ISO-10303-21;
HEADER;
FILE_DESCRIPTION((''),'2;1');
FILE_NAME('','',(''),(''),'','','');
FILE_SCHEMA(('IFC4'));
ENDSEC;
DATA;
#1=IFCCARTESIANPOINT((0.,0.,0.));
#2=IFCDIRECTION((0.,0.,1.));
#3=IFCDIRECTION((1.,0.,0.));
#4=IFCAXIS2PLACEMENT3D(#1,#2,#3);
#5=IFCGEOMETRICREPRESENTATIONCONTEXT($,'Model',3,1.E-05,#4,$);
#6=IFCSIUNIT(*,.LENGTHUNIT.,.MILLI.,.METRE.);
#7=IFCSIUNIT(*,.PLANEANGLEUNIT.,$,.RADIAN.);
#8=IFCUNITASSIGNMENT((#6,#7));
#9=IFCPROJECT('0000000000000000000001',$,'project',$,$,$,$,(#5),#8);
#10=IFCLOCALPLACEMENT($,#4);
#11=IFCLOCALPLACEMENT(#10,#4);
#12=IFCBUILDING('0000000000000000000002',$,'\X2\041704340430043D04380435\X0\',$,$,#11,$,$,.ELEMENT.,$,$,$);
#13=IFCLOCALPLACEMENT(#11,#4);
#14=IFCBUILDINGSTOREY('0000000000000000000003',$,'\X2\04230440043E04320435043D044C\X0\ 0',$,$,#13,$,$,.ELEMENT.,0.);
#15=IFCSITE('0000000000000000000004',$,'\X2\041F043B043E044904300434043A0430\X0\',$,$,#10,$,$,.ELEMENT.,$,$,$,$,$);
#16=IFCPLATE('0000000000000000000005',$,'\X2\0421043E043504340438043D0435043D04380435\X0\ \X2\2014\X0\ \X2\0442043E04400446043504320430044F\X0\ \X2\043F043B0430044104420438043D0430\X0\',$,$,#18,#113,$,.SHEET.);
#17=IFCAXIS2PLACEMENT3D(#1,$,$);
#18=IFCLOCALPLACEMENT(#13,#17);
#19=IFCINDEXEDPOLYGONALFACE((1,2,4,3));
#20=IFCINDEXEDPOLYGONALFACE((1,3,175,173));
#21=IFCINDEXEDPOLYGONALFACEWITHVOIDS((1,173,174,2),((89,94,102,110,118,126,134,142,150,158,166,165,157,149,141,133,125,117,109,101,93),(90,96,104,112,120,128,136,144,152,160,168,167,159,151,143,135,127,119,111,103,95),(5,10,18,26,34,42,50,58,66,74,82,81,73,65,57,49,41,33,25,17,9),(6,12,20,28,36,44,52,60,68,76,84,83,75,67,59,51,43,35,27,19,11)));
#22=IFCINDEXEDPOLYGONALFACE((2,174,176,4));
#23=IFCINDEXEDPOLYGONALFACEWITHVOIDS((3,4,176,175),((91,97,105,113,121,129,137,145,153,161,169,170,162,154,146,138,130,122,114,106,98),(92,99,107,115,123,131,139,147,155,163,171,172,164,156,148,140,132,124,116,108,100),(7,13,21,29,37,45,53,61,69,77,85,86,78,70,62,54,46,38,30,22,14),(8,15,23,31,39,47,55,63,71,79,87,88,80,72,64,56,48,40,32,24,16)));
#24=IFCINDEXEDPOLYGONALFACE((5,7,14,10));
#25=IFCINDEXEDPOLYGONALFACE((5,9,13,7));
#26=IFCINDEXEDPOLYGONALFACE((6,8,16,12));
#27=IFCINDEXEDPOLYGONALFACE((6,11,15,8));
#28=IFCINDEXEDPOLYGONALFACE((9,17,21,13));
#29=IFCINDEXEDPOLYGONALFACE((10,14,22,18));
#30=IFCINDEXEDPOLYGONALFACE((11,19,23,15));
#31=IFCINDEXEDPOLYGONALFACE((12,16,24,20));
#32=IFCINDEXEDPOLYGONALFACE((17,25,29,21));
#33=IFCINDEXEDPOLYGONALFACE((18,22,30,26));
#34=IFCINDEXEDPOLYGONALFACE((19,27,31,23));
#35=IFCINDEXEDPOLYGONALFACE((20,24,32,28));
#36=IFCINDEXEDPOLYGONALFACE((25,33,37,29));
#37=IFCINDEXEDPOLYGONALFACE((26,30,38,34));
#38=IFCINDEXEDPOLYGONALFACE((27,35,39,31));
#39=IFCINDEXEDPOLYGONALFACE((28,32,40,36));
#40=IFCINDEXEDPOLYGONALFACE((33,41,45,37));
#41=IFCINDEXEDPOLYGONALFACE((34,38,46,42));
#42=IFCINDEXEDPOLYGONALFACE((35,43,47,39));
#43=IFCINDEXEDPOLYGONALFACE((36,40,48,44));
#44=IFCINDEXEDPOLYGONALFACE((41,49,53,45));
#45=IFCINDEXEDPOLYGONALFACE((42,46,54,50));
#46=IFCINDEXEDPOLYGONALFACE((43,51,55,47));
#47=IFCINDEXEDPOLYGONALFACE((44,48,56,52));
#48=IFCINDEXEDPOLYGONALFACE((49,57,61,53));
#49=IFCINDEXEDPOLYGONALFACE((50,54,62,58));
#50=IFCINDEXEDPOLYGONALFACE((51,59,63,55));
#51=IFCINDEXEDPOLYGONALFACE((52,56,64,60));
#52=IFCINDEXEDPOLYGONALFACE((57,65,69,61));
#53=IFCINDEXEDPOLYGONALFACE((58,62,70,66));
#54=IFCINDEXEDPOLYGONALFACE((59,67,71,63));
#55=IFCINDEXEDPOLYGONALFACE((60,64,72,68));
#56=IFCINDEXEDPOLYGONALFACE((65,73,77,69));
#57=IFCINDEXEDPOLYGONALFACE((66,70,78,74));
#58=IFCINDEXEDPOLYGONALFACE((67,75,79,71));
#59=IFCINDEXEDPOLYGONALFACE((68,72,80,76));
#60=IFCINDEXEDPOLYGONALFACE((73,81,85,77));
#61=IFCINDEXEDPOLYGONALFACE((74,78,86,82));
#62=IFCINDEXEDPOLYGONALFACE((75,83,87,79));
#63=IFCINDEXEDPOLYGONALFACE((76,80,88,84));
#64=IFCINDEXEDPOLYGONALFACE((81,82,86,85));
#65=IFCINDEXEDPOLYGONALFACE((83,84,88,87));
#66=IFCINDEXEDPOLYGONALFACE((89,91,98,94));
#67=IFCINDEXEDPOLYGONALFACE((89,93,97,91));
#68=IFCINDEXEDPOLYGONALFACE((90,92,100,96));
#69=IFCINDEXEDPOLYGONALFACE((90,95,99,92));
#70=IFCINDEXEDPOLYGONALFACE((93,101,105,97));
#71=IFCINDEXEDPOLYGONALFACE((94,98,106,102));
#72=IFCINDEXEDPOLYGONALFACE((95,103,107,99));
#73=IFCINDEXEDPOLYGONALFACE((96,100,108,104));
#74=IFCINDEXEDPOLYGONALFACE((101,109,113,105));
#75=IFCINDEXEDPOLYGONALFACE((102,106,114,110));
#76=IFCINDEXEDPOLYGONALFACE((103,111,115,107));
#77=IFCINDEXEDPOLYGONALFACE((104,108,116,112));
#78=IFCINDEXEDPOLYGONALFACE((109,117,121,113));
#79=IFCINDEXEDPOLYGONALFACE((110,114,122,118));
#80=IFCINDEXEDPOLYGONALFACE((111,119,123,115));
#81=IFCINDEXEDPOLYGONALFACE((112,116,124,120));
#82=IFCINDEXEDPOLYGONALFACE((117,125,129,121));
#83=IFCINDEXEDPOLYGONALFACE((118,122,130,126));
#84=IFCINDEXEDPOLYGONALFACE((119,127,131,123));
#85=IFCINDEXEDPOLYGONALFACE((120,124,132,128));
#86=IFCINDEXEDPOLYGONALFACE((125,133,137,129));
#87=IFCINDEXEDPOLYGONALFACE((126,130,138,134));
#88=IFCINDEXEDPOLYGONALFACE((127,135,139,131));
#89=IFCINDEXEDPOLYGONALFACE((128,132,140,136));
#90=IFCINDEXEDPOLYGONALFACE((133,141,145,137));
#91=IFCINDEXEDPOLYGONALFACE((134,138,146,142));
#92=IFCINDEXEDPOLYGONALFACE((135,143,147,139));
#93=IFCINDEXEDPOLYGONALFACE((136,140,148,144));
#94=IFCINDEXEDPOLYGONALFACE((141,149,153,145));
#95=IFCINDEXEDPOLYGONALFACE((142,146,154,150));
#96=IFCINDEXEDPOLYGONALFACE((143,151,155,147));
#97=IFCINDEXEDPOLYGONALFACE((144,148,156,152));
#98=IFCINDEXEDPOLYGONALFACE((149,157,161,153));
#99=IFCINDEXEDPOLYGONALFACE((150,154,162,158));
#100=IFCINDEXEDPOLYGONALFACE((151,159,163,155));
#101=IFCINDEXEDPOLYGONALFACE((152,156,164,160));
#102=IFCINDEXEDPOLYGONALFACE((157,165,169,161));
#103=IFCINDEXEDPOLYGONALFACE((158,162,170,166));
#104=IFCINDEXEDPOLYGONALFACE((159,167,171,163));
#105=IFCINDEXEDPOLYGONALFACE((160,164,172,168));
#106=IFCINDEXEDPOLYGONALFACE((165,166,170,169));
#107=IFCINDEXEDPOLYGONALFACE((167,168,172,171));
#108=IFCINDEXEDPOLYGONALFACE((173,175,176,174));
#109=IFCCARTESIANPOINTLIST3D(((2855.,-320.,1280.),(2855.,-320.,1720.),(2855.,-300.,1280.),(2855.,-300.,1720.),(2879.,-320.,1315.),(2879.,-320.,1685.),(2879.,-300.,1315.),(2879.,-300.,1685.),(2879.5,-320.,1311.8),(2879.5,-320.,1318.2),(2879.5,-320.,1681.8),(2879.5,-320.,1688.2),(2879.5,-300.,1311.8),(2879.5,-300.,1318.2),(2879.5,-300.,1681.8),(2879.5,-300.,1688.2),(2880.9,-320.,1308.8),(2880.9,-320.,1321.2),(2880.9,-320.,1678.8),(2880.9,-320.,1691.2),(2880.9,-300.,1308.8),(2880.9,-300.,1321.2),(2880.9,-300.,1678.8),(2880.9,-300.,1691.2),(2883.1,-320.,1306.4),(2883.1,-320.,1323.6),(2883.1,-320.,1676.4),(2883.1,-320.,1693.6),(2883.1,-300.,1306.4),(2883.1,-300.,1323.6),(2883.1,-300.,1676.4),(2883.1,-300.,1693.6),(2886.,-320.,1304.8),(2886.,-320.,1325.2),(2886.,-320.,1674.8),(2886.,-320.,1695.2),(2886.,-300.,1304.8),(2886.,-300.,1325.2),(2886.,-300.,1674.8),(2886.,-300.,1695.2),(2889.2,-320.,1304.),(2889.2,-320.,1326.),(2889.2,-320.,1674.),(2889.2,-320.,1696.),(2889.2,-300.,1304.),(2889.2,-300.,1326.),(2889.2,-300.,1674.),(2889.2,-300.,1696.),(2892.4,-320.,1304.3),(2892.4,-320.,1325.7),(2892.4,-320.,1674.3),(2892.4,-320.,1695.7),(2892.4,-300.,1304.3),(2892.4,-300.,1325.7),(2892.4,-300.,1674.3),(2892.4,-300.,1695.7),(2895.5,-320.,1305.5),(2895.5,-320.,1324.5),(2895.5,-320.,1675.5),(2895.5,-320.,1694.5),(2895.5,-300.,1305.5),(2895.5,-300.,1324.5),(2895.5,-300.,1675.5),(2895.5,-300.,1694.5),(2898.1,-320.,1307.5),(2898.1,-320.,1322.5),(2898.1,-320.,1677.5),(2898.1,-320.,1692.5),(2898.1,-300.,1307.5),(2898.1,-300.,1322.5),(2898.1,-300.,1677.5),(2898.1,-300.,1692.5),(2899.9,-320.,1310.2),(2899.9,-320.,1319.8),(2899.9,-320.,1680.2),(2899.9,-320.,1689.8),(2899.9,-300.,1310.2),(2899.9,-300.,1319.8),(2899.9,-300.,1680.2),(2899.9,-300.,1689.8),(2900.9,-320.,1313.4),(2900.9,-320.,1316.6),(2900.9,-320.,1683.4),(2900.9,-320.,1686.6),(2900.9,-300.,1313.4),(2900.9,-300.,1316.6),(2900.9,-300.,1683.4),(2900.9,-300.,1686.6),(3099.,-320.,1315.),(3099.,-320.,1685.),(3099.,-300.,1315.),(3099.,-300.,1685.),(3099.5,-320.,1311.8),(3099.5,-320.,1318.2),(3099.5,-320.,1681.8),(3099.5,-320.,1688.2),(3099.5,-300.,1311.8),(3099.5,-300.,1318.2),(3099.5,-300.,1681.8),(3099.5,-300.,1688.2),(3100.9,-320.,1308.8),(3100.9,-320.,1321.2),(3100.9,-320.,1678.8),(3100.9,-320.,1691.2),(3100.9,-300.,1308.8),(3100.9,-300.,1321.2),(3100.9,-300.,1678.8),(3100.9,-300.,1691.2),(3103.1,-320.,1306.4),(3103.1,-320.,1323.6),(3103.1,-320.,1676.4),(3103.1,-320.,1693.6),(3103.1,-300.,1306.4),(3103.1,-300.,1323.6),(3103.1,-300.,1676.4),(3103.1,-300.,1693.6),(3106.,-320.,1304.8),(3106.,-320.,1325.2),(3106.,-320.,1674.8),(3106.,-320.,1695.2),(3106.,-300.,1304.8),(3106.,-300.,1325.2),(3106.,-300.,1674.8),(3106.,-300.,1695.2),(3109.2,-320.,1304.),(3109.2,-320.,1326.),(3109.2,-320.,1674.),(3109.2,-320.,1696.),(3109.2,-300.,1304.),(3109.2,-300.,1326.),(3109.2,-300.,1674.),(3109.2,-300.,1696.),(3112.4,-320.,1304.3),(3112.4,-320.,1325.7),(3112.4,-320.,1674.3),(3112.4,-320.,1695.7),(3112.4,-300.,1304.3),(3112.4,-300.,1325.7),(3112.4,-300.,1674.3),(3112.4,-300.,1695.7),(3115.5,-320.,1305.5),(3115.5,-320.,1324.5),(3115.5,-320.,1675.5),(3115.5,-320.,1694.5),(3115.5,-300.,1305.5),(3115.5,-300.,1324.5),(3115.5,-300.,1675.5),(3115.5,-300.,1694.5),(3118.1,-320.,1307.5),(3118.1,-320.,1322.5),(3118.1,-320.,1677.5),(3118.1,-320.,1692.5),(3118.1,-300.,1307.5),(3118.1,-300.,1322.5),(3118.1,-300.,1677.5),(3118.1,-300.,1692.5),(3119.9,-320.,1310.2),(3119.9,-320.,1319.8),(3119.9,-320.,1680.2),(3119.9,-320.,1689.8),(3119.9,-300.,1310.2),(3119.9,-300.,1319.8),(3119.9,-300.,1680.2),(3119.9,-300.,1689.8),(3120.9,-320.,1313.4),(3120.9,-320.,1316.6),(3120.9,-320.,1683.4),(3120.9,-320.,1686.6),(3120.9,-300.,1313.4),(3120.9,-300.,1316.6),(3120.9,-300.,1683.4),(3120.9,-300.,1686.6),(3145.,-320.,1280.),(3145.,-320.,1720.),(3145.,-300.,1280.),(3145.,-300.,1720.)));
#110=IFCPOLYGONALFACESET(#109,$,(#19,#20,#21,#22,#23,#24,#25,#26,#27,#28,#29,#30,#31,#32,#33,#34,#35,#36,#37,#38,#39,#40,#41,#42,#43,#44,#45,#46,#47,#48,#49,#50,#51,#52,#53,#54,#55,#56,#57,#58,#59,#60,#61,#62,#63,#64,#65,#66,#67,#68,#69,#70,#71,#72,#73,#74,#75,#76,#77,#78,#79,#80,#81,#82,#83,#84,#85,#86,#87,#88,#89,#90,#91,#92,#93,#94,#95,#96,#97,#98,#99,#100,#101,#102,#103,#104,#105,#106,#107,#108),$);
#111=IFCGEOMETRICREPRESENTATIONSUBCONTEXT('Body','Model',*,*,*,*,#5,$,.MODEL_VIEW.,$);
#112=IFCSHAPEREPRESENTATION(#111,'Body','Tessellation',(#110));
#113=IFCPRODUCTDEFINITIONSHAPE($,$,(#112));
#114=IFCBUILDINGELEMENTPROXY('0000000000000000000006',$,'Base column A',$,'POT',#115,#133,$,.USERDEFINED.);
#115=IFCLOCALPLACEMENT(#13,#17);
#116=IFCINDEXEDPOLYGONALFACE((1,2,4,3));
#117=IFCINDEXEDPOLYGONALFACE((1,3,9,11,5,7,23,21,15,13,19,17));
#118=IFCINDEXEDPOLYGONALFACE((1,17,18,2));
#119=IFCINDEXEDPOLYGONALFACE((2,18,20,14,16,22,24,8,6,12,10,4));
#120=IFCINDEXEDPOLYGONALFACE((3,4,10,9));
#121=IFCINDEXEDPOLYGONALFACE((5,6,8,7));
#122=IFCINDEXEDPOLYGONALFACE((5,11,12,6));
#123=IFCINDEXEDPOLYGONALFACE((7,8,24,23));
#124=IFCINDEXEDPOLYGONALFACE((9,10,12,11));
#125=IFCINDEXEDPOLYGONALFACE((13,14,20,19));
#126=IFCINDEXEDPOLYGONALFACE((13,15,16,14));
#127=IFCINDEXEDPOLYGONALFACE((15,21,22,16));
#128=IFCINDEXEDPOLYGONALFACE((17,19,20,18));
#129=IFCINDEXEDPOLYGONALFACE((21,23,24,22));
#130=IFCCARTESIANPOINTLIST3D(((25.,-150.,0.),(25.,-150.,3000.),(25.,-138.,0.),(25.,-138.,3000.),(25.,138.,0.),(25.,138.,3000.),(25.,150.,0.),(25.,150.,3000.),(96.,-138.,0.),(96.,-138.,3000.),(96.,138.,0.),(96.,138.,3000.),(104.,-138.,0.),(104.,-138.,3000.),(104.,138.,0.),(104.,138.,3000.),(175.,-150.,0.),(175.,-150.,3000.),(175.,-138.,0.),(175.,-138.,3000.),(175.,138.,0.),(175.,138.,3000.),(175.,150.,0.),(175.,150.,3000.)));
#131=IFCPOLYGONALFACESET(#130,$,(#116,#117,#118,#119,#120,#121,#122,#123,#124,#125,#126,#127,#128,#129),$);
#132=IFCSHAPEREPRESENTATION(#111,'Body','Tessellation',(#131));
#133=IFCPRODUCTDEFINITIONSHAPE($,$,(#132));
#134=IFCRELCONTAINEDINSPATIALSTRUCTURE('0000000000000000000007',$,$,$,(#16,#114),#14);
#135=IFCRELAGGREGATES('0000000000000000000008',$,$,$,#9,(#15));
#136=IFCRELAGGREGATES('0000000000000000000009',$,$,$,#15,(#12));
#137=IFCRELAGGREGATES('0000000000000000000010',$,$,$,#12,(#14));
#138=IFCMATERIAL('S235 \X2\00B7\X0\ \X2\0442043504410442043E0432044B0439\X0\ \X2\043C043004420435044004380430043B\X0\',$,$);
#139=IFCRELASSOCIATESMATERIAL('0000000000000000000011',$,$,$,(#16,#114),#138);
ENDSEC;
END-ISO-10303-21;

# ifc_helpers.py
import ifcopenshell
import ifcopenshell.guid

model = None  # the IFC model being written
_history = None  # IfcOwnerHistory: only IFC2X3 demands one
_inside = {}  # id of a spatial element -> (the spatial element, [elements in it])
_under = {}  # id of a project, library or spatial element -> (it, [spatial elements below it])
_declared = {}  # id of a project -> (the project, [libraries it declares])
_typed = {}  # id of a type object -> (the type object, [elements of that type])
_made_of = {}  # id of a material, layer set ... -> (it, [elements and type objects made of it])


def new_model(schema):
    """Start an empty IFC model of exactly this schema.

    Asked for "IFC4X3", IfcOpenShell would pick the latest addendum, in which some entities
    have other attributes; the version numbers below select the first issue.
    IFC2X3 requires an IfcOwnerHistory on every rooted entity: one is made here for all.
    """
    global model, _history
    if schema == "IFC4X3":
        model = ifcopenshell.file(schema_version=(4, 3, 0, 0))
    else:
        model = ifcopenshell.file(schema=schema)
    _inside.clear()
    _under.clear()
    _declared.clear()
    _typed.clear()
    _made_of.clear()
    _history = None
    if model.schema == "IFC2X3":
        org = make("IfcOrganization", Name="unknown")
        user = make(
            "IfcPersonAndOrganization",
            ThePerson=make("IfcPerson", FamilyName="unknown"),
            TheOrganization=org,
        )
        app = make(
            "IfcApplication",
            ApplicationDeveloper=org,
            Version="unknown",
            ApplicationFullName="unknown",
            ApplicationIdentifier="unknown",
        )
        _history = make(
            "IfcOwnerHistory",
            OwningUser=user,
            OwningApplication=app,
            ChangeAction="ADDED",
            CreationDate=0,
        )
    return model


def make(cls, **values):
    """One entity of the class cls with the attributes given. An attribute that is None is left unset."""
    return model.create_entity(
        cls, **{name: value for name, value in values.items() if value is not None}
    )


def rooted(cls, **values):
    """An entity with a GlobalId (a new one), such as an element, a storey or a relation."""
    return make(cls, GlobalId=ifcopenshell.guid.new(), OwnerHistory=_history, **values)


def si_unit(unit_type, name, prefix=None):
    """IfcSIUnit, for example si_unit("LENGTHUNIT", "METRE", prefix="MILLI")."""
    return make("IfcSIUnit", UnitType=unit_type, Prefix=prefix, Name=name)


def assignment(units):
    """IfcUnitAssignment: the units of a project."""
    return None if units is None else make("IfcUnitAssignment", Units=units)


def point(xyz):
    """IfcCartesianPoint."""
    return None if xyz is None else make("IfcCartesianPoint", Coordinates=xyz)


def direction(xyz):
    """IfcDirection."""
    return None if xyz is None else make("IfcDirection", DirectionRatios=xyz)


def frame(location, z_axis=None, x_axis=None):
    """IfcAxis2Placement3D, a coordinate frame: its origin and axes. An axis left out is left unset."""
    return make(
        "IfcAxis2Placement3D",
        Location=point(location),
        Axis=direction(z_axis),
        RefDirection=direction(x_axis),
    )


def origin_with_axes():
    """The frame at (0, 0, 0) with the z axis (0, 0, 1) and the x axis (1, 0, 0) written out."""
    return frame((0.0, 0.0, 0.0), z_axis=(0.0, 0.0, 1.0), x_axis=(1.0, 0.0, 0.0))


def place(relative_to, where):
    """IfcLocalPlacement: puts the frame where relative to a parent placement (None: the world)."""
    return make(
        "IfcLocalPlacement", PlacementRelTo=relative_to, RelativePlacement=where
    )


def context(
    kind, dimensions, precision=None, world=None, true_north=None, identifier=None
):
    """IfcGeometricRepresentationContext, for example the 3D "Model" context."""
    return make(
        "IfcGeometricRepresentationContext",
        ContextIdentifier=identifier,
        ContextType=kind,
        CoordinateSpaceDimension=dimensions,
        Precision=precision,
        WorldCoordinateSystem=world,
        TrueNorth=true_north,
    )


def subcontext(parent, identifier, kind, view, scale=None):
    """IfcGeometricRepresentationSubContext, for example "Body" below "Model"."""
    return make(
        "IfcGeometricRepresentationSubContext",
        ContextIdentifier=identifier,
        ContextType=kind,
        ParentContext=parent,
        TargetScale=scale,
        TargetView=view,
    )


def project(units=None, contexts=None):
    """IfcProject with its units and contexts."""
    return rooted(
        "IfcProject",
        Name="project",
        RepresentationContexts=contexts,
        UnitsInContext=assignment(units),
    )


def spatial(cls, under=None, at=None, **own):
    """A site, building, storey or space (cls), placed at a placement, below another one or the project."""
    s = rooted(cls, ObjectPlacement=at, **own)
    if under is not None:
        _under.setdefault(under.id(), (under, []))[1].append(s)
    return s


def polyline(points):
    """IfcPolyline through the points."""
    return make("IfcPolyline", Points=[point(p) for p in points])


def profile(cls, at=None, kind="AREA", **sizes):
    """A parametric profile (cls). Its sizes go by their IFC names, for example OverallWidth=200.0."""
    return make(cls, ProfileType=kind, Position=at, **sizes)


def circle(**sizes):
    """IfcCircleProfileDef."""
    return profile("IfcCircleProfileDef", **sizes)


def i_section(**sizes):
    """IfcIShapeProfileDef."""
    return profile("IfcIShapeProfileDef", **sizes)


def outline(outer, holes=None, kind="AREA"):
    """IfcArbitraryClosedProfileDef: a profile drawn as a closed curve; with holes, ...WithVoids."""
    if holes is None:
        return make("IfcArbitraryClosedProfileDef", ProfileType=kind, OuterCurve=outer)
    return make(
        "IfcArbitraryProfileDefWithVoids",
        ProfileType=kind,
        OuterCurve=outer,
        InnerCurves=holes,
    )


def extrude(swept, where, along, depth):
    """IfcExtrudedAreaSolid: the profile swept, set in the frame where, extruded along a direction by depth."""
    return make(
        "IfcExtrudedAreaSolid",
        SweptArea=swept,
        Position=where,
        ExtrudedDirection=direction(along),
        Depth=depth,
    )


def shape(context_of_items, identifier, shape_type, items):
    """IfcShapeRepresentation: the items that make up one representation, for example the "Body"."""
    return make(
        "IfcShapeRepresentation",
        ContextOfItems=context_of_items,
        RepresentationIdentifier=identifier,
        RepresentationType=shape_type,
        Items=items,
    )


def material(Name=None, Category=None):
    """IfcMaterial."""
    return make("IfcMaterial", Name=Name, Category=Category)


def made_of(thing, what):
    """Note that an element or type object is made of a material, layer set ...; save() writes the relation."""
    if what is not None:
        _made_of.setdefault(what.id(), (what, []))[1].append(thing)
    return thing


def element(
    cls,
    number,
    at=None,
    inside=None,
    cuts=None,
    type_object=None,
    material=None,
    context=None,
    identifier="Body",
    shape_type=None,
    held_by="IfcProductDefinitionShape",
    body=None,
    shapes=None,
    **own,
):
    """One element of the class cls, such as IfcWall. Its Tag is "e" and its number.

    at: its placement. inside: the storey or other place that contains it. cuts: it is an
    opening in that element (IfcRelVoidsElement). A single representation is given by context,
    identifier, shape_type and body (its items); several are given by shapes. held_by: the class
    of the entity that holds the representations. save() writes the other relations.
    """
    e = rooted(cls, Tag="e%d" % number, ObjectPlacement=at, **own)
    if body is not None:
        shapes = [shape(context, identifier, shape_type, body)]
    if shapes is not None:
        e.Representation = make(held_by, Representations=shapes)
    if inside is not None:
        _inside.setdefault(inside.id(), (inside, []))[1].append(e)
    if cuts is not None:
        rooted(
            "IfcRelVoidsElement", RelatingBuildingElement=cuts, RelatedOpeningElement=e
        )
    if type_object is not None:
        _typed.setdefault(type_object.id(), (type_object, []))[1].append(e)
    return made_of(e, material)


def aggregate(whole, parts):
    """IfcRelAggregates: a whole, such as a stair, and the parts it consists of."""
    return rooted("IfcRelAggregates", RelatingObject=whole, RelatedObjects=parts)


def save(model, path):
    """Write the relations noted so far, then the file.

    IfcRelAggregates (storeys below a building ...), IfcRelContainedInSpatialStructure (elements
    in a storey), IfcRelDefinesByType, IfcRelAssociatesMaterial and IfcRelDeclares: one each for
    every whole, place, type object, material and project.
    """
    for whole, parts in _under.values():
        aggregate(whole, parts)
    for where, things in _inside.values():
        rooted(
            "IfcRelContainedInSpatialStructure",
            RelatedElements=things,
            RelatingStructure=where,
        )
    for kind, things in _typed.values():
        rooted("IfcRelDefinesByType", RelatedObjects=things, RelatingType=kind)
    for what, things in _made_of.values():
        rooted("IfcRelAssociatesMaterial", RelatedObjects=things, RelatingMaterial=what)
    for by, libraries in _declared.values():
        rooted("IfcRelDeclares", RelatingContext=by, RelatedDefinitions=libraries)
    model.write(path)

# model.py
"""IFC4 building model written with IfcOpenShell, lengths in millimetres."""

from ifc_helpers import new_model, si_unit, frame, origin_with_axes, place, context, subcontext, project, spatial, polyline, circle, i_section, outline, extrude, material, element, save


model = new_model("IFC4")

# Units and contexts
model_context = context("Model", 3, precision=1e-05, world=origin_with_axes())
body_context = subcontext(model_context, "Body", "Model", "MODEL_VIEW")
ifc_project = project(units=[si_unit("LENGTHUNIT", "METRE", prefix="MILLI"), si_unit("PLANEANGLEUNIT", "RADIAN")], contexts=[model_context])

# Site, building, storey
site_placement = place(None, origin_with_axes())
site = spatial("IfcSite", under=ifc_project, at=site_placement, Name="Площадка", CompositionType="ELEMENT")
building_placement = place(site_placement, origin_with_axes())
building = spatial("IfcBuilding", under=site, at=building_placement, Name="Здание", CompositionType="ELEMENT")
storey_placement = place(building_placement, origin_with_axes())
storey = spatial("IfcBuildingStorey", under=building, at=storey_placement, Name="Уровень 0", CompositionType="ELEMENT", Elevation=0.0)

# Shared definitions
ifc_material = material(Name="S235 · тестовый материал")

# Plate, openings
plate_1_placement = place(storey_placement, frame((3145.0, -320.0, 1280.0), z_axis=(0.0, 1.0, 0.0), x_axis=(-1.0, 0.0, 0.0)))
plate_1 = element("IfcPlate", 1, at=plate_1_placement, inside=storey, material=ifc_material, Name="Соединение — торцевая пластина", PredefinedType="SHEET", context=body_context, shape_type="SweptSolid", body=[
    extrude(outline(polyline([(0.0, 0.0), (290.0, 0.0), (290.0, 440.0), (0.0, 440.0), (0.0, 0.0)])), origin_with_axes(), (0.0, 0.0, 1.0), 20.0),
])
opening_1_placement = place(plate_1_placement, frame((35.0, 35.0, -1.0), z_axis=(0.0, 0.0, 1.0), x_axis=(1.0, 0.0, 0.0)))
element("IfcOpeningElement", 2, at=opening_1_placement, cuts=plate_1, PredefinedType="OPENING", context=body_context, shape_type="SweptSolid", body=[
    extrude(circle(Radius=11.0), origin_with_axes(), (0.0, 0.0, 1.0), 42.0),
])
opening_2_placement = place(plate_1_placement, frame((35.0, 405.0, -1.0), z_axis=(0.0, 0.0, 1.0), x_axis=(1.0, 0.0, 0.0)))
element("IfcOpeningElement", 3, at=opening_2_placement, cuts=plate_1, PredefinedType="OPENING", context=body_context, shape_type="SweptSolid", body=[
    extrude(circle(Radius=11.0), origin_with_axes(), (0.0, 0.0, 1.0), 42.0),
])
opening_3_placement = place(plate_1_placement, frame((255.0, 35.0, -1.0), z_axis=(0.0, 0.0, 1.0), x_axis=(1.0, 0.0, 0.0)))
element("IfcOpeningElement", 4, at=opening_3_placement, cuts=plate_1, PredefinedType="OPENING", context=body_context, shape_type="SweptSolid", body=[
    extrude(circle(Radius=11.0), origin_with_axes(), (0.0, 0.0, 1.0), 42.0),
])
opening_4_placement = place(plate_1_placement, frame((255.0, 405.0, -1.0), z_axis=(0.0, 0.0, 1.0), x_axis=(1.0, 0.0, 0.0)))
element("IfcOpeningElement", 5, at=opening_4_placement, cuts=plate_1, PredefinedType="OPENING", context=body_context, shape_type="SweptSolid", body=[
    extrude(circle(Radius=11.0), origin_with_axes(), (0.0, 0.0, 1.0), 42.0),
])

# Building element proxy
proxy_placement = place(storey_placement, frame((100.0, 0.0, 0.0), z_axis=(0.0, 0.0, 1.0), x_axis=(1.0, 0.0, 0.0)))
element("IfcBuildingElementProxy", 6, at=proxy_placement, inside=storey, material=ifc_material, Name="Base column A", ObjectType="POT", PredefinedType="USERDEFINED", context=body_context, shape_type="SweptSolid", body=[
    extrude(i_section(OverallWidth=150.0, OverallDepth=300.0, WebThickness=8.0, FlangeThickness=12.0), origin_with_axes(), (0.0, 0.0, 1.0), 3000.0),
])

save(model, "model.ifc")
